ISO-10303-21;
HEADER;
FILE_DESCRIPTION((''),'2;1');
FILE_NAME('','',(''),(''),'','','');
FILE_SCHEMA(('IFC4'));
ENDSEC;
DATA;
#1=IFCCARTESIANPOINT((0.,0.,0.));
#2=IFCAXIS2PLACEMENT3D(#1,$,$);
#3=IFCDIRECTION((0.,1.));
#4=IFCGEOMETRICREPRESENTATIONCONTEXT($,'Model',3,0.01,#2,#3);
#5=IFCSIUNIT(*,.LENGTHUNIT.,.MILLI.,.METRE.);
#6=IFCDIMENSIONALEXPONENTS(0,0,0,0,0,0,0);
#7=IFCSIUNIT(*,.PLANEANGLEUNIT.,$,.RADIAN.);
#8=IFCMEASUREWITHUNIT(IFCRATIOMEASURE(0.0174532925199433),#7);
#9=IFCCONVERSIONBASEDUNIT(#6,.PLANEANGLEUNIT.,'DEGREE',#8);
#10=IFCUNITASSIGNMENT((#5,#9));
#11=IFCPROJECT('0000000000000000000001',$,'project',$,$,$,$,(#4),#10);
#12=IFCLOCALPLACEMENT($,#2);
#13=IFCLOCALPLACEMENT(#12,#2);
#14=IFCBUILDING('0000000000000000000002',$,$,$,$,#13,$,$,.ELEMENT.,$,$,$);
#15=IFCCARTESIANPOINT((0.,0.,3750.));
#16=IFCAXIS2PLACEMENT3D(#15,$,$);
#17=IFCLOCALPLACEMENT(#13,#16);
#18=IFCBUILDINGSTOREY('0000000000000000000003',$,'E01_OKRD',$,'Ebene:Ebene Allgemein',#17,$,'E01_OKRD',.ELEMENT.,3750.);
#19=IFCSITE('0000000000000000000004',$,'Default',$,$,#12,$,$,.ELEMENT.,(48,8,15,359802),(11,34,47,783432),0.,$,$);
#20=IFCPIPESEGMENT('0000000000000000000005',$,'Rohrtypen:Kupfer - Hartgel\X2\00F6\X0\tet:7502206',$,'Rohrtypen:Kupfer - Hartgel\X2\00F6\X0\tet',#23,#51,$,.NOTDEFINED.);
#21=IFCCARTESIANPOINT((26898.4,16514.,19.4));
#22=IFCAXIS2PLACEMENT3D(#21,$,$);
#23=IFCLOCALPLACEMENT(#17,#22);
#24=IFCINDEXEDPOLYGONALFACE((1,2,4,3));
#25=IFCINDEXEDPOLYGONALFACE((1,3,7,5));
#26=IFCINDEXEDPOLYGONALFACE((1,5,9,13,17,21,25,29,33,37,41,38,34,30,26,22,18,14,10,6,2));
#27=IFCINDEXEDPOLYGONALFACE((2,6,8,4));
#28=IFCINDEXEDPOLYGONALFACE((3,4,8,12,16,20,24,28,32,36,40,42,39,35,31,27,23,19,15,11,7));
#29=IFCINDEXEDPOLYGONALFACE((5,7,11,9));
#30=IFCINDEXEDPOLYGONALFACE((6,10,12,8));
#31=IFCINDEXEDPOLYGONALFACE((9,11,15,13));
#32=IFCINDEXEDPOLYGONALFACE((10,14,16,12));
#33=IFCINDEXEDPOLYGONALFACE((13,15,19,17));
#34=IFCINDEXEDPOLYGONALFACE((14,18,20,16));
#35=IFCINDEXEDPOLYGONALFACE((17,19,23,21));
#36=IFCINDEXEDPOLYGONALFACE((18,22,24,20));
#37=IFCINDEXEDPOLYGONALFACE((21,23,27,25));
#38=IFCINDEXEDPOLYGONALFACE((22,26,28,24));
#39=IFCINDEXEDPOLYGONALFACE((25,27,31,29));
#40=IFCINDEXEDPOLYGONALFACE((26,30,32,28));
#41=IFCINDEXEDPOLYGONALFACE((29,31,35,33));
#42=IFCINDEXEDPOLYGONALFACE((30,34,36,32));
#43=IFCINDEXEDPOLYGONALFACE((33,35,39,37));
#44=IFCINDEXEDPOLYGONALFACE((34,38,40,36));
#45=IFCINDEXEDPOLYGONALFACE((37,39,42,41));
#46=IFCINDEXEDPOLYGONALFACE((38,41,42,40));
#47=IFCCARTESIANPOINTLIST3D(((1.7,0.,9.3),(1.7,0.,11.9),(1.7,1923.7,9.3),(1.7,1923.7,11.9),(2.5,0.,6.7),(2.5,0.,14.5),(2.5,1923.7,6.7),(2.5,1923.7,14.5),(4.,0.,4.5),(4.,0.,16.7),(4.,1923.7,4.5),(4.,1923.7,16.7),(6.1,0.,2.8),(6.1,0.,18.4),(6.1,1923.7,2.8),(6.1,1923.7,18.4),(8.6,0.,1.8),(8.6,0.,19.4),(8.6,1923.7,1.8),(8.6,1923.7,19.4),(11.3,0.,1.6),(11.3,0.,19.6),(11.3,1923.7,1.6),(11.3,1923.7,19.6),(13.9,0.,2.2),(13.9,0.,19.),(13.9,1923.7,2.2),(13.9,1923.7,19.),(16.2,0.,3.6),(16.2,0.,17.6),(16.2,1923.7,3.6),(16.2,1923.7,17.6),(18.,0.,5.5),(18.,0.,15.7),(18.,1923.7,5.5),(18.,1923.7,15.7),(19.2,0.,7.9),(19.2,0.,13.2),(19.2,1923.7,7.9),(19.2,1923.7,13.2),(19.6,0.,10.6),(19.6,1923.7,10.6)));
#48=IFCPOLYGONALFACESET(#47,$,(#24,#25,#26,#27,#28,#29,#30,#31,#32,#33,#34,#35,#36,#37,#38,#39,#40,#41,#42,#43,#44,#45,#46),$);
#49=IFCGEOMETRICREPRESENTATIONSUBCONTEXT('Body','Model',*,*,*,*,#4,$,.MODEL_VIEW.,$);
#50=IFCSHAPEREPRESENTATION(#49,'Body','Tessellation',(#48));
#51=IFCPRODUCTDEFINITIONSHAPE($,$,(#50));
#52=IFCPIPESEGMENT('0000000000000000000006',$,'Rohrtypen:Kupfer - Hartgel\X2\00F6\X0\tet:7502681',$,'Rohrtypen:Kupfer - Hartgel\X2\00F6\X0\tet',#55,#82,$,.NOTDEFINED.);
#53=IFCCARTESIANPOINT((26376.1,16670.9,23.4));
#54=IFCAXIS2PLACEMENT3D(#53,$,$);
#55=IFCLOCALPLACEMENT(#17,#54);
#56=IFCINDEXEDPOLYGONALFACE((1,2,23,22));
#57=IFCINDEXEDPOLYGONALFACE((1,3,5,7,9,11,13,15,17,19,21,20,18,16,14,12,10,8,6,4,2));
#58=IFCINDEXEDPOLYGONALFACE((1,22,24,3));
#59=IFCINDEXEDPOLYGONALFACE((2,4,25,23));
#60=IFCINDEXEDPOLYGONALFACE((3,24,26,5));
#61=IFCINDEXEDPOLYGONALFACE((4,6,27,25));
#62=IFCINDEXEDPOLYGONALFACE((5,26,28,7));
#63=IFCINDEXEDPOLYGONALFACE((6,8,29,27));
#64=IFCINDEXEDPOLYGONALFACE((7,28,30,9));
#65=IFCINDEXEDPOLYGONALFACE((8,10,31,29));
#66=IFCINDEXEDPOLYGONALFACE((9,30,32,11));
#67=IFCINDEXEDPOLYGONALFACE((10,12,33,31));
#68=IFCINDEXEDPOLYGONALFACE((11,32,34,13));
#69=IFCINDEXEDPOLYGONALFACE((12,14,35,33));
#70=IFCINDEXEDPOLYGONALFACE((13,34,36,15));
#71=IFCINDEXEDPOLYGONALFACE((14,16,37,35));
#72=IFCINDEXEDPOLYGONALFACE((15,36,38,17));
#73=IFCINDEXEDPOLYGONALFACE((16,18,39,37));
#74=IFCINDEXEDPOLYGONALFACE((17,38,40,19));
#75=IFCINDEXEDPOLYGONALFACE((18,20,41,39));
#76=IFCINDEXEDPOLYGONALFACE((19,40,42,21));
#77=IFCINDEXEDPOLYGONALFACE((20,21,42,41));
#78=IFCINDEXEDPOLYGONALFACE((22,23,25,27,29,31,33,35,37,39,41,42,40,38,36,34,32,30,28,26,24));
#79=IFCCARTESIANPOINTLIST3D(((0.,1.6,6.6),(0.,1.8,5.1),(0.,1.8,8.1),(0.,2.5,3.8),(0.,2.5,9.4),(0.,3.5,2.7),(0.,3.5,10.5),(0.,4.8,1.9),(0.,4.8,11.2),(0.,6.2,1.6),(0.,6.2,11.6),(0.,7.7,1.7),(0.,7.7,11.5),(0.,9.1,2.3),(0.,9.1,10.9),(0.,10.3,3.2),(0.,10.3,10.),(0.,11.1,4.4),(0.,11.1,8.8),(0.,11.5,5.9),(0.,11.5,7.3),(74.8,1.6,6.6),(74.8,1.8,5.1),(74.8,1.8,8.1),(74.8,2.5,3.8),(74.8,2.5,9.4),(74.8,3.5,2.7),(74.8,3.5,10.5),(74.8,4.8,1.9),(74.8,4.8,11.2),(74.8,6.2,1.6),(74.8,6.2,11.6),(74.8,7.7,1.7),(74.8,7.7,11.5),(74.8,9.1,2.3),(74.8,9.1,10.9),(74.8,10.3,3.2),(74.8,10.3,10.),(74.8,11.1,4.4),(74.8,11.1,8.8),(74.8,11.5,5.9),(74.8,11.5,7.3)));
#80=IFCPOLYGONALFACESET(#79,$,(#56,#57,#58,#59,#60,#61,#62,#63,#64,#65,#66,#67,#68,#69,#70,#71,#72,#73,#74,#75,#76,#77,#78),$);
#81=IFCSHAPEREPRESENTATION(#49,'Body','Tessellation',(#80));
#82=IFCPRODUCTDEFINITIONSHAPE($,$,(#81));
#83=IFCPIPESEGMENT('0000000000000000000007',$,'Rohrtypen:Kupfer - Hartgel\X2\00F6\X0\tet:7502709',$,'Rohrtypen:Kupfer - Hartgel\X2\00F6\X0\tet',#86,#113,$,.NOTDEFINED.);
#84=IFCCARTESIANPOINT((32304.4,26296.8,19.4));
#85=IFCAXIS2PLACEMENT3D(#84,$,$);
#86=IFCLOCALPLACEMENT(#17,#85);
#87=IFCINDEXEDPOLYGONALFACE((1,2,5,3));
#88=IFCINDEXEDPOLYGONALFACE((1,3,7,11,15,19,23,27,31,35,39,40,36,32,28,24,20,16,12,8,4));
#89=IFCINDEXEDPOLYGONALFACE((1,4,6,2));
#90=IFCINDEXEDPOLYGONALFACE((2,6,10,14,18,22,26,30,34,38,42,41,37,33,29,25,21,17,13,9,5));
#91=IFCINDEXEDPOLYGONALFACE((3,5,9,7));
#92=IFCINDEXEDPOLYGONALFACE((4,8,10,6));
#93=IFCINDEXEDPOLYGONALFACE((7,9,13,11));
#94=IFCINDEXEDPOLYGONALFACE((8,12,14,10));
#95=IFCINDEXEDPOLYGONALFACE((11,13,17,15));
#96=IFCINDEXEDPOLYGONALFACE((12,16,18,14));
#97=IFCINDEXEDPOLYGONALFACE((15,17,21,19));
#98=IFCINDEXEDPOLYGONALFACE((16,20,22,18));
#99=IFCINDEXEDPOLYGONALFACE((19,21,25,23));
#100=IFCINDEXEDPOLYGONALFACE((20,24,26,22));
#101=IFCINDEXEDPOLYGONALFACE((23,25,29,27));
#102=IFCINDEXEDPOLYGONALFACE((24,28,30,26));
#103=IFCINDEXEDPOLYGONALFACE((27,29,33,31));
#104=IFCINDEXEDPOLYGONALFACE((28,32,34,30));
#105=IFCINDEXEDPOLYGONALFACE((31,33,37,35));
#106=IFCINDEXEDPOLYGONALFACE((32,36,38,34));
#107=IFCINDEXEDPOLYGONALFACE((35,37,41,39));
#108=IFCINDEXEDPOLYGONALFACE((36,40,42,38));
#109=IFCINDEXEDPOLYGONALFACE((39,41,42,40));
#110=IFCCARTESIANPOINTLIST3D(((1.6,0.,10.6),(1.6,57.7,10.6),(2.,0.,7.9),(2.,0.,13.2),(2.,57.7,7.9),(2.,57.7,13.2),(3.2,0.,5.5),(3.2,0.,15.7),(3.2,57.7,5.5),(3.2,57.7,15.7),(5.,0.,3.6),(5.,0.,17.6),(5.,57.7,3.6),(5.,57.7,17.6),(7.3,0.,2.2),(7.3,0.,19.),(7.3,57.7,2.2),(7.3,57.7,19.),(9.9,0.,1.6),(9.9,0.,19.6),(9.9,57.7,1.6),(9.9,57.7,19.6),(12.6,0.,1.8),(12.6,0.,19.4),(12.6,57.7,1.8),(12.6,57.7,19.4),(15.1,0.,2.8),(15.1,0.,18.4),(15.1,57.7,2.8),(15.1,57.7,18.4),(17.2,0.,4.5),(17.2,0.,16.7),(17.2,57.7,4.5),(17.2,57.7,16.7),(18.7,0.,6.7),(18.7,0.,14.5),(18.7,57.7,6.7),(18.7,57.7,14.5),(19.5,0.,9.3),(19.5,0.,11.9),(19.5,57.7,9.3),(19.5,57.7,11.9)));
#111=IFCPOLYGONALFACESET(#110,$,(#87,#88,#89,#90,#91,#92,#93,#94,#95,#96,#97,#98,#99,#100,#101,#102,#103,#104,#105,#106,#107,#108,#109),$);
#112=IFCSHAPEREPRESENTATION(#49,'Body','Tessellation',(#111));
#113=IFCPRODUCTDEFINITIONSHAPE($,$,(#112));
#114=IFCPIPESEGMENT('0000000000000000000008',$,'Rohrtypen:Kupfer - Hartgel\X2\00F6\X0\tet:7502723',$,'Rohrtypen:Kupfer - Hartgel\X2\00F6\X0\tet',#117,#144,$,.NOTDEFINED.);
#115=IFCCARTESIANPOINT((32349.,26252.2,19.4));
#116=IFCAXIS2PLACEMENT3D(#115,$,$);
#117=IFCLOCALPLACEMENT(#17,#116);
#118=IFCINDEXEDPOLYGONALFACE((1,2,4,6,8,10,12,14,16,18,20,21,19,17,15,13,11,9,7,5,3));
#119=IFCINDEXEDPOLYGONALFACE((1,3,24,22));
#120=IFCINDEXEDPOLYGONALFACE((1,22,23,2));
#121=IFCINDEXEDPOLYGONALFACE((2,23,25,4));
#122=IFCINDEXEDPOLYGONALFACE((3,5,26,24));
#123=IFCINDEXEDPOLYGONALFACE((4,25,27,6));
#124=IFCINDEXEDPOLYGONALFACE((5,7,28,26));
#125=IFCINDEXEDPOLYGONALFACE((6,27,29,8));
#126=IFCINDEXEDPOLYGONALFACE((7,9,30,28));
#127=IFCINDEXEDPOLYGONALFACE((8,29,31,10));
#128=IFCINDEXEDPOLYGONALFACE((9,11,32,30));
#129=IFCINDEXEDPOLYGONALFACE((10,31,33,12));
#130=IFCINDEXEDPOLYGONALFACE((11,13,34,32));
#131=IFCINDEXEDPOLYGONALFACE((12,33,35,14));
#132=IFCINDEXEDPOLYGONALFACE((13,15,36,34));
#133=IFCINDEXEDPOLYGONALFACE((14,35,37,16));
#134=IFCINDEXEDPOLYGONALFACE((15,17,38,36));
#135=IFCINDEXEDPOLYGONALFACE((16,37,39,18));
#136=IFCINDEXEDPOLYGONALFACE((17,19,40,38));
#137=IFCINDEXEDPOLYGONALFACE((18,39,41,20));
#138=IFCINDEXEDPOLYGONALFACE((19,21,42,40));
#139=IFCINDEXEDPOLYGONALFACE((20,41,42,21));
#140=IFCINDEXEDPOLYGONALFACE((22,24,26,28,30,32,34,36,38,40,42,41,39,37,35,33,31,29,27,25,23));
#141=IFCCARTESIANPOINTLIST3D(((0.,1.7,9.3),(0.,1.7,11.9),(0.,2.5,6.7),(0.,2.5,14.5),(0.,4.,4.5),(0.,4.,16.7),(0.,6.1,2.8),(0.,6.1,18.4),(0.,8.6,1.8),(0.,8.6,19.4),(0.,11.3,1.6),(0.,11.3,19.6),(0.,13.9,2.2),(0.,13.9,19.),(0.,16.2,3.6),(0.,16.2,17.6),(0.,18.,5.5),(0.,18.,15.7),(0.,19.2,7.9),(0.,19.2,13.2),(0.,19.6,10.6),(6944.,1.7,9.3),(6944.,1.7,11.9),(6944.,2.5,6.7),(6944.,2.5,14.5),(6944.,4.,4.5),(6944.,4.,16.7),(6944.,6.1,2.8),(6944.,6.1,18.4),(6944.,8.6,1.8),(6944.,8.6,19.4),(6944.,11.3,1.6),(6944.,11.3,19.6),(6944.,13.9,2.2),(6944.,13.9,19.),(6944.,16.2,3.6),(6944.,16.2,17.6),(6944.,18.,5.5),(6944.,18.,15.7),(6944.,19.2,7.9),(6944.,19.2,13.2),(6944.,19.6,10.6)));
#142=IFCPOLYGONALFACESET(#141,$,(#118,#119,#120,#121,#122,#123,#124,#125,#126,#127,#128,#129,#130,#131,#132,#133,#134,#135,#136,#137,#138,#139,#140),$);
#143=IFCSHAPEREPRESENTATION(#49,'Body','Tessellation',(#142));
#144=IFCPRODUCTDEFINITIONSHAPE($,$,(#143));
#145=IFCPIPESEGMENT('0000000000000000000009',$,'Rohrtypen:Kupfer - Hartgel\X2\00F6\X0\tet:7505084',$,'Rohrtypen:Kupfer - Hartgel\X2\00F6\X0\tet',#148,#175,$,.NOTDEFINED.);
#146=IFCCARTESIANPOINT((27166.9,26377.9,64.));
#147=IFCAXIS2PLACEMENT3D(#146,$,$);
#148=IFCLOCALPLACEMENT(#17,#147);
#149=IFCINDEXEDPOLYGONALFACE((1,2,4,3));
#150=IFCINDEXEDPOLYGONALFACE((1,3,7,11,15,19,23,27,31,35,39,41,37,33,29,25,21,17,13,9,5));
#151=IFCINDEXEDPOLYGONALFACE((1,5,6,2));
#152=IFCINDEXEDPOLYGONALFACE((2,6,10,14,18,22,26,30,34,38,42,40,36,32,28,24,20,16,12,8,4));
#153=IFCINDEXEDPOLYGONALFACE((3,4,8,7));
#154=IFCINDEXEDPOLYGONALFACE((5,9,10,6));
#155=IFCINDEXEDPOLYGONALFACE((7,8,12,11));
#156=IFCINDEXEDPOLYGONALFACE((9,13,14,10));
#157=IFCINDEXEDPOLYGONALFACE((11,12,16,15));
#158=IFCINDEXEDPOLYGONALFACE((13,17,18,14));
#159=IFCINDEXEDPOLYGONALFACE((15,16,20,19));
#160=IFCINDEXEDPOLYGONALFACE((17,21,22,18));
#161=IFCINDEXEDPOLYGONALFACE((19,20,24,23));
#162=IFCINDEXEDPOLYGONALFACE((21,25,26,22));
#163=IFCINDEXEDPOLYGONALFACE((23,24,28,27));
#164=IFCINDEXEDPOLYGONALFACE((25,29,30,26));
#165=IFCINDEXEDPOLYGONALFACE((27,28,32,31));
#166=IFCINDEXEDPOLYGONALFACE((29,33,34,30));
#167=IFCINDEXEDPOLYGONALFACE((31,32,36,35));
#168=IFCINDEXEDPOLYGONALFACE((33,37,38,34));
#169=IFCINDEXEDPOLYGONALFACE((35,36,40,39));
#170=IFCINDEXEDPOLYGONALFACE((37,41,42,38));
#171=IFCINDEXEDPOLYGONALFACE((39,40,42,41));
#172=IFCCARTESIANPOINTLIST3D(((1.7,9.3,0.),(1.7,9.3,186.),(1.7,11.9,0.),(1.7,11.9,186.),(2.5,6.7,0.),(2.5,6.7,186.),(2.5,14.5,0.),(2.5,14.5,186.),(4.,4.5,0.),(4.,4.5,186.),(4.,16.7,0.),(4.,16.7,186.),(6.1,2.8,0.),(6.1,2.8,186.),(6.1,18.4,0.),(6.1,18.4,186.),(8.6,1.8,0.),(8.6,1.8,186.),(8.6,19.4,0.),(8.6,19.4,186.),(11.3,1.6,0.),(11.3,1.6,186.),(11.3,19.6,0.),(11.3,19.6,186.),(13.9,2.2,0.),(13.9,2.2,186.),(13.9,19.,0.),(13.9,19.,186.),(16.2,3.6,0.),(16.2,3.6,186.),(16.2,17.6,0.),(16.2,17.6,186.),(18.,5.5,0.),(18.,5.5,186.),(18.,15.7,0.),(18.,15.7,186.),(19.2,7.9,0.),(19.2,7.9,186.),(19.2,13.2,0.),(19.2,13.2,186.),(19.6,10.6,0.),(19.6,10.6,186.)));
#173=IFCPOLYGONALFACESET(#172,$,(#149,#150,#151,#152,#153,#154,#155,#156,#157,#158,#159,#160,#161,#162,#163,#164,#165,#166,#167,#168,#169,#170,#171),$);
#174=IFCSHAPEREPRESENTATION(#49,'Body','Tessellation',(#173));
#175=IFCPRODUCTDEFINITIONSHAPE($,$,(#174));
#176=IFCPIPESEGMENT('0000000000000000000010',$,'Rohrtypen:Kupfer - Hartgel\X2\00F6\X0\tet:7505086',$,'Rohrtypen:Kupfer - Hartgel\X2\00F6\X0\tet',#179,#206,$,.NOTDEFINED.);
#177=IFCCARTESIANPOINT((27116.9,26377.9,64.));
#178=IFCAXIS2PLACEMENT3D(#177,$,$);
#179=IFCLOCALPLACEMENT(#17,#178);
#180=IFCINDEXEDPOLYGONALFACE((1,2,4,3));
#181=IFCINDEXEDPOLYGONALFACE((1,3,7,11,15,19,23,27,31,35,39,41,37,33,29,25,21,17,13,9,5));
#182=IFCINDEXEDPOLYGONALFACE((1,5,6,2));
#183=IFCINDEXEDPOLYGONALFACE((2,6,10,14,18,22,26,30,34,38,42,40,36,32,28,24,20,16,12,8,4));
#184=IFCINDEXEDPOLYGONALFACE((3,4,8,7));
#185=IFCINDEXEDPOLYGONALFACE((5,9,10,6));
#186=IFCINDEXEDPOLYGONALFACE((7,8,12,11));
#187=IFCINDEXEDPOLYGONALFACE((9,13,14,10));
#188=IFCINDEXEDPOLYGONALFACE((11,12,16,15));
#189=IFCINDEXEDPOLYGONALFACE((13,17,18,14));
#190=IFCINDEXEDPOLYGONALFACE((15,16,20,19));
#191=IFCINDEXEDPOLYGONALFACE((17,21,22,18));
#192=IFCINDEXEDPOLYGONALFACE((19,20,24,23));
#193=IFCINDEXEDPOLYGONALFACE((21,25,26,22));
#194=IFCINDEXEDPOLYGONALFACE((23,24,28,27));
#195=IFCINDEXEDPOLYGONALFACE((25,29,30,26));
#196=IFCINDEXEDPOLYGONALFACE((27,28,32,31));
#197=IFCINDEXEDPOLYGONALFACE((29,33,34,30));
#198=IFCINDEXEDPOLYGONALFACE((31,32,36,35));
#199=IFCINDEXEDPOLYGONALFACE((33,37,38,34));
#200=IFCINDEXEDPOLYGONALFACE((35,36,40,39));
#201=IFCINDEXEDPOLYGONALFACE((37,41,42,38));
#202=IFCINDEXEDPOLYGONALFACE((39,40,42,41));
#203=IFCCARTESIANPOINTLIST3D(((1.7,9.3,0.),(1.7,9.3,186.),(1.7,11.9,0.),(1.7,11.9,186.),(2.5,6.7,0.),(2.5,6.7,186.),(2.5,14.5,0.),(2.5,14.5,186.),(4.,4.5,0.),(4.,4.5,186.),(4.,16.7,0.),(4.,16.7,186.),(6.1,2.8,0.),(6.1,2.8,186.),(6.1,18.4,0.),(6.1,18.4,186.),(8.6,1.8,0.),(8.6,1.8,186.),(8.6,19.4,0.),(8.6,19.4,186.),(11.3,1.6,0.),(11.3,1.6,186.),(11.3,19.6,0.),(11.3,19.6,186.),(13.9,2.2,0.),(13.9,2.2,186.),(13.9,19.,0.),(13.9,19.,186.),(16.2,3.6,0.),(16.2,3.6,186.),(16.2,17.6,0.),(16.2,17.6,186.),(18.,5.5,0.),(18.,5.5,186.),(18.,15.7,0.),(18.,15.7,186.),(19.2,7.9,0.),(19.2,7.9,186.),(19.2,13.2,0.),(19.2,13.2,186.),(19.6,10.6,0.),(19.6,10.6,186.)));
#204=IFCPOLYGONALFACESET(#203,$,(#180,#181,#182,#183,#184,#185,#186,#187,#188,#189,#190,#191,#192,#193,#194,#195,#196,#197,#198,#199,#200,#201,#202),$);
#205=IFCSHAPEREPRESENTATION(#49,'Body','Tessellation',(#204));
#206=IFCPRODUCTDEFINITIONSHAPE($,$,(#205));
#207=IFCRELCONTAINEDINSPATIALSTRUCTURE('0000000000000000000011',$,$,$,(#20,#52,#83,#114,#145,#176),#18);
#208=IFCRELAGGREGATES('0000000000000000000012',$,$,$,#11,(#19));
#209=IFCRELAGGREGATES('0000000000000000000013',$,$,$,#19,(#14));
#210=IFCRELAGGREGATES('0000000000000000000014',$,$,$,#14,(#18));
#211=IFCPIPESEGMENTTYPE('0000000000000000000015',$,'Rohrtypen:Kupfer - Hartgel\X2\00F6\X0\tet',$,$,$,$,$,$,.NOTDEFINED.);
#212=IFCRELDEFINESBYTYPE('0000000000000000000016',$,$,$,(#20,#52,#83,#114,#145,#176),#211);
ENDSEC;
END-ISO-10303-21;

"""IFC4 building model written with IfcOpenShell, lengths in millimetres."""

from ifc_helpers import new_model, entity, si_unit, converted_unit, direction, frame, frame_2d, origin, origin_2d_with_axis, place, context, subcontext, project, spatial, circle, extrude, type_object, element, save


model = new_model("IFC4")

# Units and contexts
model_context = context("Model", 3, precision=0.01, world=origin(), true_north=direction((0.0, 1.0)))
body_context = subcontext(model_context, "Body", "Model", "MODEL_VIEW")
ifc_project = project(units=[si_unit("LENGTHUNIT", "METRE", prefix="MILLI"), converted_unit("PLANEANGLEUNIT", "DEGREE", entity("IfcRatioMeasure", 0.0174532925199433), si_unit("PLANEANGLEUNIT", "RADIAN"), dimensions=[0, 0, 0, 0, 0, 0, 0])], contexts=[model_context])

# Site, building, storey
site_placement = place(None, origin())
site = spatial("IfcSite", under=ifc_project, at=site_placement, Name="Default", CompositionType="ELEMENT", RefLatitude=(48, 8, 15, 359802), RefLongitude=(11, 34, 47, 783432), RefElevation=0.0)
building_placement = place(site_placement, origin())
building = spatial("IfcBuilding", under=site, at=building_placement, CompositionType="ELEMENT")
storey_placement = place(building_placement, frame((0.0, 0.0, 3750.0)))
storey = spatial("IfcBuildingStorey", under=building, at=storey_placement, Name="E01_OKRD", ObjectType="Ebene:Ebene Allgemein", LongName="E01_OKRD", CompositionType="ELEMENT", Elevation=3750.0)

# Pipe segments
pipe_segment_type = type_object("IfcPipeSegmentType", Name="Rohrtypen:Kupfer - Hartgelötet", PredefinedType="NOTDEFINED")
pipe_segment_1_placement = place(storey_placement, frame((26898.4, 16514.0, 19.4)))
element("IfcPipeSegment", 1, at=pipe_segment_1_placement, inside=storey, type_object=pipe_segment_type, Name="Rohrtypen:Kupfer - Hartgelötet:7502206", ObjectType="Rohrtypen:Kupfer - Hartgelötet", PredefinedType="NOTDEFINED", context=body_context, shape_type="SweptSolid", body=[
    extrude(circle(Radius=9.0, at=origin_2d_with_axis()), frame((10.6, 0.0, 10.6), z_axis=(0.0, 1.0, 0.0), x_axis=(1.0, 0.0, 0.0)), (0.0, 0.0, 1.0), 1923.7),
])
pipe_segment_2_placement = place(storey_placement, frame((26376.1, 16670.9, 23.4)))
element("IfcPipeSegment", 2, at=pipe_segment_2_placement, inside=storey, type_object=pipe_segment_type, Name="Rohrtypen:Kupfer - Hartgelötet:7502681", ObjectType="Rohrtypen:Kupfer - Hartgelötet", PredefinedType="NOTDEFINED", context=body_context, shape_type="SweptSolid", body=[
    extrude(circle(Radius=5.0, at=origin_2d_with_axis()), frame((0.0, 6.6, 6.6), z_axis=(1.0, 0.0, 0.0), x_axis=(0.0, -1.0, 0.0)), (0.0, 0.0, 1.0), 74.8),
])
pipe_segment_3_placement = place(storey_placement, frame((32304.4, 26296.8, 19.4)))
element("IfcPipeSegment", 3, at=pipe_segment_3_placement, inside=storey, type_object=pipe_segment_type, Name="Rohrtypen:Kupfer - Hartgelötet:7502709", ObjectType="Rohrtypen:Kupfer - Hartgelötet", PredefinedType="NOTDEFINED", context=body_context, shape_type="SweptSolid", body=[
    extrude(circle(Radius=9.0, at=frame_2d((0.0, 0.0), x_axis=(1.0, 0.0))), frame((10.6, 0.0, 10.6), z_axis=(0.0, 1.0, 0.0), x_axis=(-1.0, 0.0, 0.0)), (0.0, 0.0, 1.0), 57.7),
])
pipe_segment_4_placement = place(storey_placement, frame((32349.0, 26252.2, 19.4)))
element("IfcPipeSegment", 4, at=pipe_segment_4_placement, inside=storey, type_object=pipe_segment_type, Name="Rohrtypen:Kupfer - Hartgelötet:7502723", ObjectType="Rohrtypen:Kupfer - Hartgelötet", PredefinedType="NOTDEFINED", context=body_context, shape_type="SweptSolid", body=[
    extrude(circle(Radius=9.0, at=origin_2d_with_axis()), frame((0.0, 10.6, 10.6), z_axis=(1.0, 0.0, 0.0), x_axis=(0.0, 1.0, 0.0)), (0.0, 0.0, 1.0), 6944.0),
])
pipe_segment_5_placement = place(storey_placement, frame((27166.9, 26377.9, 64.0)))
element("IfcPipeSegment", 5, at=pipe_segment_5_placement, inside=storey, type_object=pipe_segment_type, Name="Rohrtypen:Kupfer - Hartgelötet:7505084", ObjectType="Rohrtypen:Kupfer - Hartgelötet", PredefinedType="NOTDEFINED", context=body_context, shape_type="SweptSolid", body=[
    extrude(circle(Radius=9.0, at=origin_2d_with_axis()), frame((10.6, 10.6, 0.0)), (0.0, 0.0, 1.0), 186.0),
])
pipe_segment_6_placement = place(storey_placement, frame((27116.9, 26377.9, 64.0)))
element("IfcPipeSegment", 6, at=pipe_segment_6_placement, inside=storey, type_object=pipe_segment_type, Name="Rohrtypen:Kupfer - Hartgelötet:7505086", ObjectType="Rohrtypen:Kupfer - Hartgelötet", PredefinedType="NOTDEFINED", context=body_context, shape_type="SweptSolid", body=[
    extrude(circle(Radius=9.0, at=origin_2d_with_axis()), frame((10.6, 10.6, 0.0)), (0.0, 0.0, 1.0), 186.0),
])

save(model, "model.ifc")
